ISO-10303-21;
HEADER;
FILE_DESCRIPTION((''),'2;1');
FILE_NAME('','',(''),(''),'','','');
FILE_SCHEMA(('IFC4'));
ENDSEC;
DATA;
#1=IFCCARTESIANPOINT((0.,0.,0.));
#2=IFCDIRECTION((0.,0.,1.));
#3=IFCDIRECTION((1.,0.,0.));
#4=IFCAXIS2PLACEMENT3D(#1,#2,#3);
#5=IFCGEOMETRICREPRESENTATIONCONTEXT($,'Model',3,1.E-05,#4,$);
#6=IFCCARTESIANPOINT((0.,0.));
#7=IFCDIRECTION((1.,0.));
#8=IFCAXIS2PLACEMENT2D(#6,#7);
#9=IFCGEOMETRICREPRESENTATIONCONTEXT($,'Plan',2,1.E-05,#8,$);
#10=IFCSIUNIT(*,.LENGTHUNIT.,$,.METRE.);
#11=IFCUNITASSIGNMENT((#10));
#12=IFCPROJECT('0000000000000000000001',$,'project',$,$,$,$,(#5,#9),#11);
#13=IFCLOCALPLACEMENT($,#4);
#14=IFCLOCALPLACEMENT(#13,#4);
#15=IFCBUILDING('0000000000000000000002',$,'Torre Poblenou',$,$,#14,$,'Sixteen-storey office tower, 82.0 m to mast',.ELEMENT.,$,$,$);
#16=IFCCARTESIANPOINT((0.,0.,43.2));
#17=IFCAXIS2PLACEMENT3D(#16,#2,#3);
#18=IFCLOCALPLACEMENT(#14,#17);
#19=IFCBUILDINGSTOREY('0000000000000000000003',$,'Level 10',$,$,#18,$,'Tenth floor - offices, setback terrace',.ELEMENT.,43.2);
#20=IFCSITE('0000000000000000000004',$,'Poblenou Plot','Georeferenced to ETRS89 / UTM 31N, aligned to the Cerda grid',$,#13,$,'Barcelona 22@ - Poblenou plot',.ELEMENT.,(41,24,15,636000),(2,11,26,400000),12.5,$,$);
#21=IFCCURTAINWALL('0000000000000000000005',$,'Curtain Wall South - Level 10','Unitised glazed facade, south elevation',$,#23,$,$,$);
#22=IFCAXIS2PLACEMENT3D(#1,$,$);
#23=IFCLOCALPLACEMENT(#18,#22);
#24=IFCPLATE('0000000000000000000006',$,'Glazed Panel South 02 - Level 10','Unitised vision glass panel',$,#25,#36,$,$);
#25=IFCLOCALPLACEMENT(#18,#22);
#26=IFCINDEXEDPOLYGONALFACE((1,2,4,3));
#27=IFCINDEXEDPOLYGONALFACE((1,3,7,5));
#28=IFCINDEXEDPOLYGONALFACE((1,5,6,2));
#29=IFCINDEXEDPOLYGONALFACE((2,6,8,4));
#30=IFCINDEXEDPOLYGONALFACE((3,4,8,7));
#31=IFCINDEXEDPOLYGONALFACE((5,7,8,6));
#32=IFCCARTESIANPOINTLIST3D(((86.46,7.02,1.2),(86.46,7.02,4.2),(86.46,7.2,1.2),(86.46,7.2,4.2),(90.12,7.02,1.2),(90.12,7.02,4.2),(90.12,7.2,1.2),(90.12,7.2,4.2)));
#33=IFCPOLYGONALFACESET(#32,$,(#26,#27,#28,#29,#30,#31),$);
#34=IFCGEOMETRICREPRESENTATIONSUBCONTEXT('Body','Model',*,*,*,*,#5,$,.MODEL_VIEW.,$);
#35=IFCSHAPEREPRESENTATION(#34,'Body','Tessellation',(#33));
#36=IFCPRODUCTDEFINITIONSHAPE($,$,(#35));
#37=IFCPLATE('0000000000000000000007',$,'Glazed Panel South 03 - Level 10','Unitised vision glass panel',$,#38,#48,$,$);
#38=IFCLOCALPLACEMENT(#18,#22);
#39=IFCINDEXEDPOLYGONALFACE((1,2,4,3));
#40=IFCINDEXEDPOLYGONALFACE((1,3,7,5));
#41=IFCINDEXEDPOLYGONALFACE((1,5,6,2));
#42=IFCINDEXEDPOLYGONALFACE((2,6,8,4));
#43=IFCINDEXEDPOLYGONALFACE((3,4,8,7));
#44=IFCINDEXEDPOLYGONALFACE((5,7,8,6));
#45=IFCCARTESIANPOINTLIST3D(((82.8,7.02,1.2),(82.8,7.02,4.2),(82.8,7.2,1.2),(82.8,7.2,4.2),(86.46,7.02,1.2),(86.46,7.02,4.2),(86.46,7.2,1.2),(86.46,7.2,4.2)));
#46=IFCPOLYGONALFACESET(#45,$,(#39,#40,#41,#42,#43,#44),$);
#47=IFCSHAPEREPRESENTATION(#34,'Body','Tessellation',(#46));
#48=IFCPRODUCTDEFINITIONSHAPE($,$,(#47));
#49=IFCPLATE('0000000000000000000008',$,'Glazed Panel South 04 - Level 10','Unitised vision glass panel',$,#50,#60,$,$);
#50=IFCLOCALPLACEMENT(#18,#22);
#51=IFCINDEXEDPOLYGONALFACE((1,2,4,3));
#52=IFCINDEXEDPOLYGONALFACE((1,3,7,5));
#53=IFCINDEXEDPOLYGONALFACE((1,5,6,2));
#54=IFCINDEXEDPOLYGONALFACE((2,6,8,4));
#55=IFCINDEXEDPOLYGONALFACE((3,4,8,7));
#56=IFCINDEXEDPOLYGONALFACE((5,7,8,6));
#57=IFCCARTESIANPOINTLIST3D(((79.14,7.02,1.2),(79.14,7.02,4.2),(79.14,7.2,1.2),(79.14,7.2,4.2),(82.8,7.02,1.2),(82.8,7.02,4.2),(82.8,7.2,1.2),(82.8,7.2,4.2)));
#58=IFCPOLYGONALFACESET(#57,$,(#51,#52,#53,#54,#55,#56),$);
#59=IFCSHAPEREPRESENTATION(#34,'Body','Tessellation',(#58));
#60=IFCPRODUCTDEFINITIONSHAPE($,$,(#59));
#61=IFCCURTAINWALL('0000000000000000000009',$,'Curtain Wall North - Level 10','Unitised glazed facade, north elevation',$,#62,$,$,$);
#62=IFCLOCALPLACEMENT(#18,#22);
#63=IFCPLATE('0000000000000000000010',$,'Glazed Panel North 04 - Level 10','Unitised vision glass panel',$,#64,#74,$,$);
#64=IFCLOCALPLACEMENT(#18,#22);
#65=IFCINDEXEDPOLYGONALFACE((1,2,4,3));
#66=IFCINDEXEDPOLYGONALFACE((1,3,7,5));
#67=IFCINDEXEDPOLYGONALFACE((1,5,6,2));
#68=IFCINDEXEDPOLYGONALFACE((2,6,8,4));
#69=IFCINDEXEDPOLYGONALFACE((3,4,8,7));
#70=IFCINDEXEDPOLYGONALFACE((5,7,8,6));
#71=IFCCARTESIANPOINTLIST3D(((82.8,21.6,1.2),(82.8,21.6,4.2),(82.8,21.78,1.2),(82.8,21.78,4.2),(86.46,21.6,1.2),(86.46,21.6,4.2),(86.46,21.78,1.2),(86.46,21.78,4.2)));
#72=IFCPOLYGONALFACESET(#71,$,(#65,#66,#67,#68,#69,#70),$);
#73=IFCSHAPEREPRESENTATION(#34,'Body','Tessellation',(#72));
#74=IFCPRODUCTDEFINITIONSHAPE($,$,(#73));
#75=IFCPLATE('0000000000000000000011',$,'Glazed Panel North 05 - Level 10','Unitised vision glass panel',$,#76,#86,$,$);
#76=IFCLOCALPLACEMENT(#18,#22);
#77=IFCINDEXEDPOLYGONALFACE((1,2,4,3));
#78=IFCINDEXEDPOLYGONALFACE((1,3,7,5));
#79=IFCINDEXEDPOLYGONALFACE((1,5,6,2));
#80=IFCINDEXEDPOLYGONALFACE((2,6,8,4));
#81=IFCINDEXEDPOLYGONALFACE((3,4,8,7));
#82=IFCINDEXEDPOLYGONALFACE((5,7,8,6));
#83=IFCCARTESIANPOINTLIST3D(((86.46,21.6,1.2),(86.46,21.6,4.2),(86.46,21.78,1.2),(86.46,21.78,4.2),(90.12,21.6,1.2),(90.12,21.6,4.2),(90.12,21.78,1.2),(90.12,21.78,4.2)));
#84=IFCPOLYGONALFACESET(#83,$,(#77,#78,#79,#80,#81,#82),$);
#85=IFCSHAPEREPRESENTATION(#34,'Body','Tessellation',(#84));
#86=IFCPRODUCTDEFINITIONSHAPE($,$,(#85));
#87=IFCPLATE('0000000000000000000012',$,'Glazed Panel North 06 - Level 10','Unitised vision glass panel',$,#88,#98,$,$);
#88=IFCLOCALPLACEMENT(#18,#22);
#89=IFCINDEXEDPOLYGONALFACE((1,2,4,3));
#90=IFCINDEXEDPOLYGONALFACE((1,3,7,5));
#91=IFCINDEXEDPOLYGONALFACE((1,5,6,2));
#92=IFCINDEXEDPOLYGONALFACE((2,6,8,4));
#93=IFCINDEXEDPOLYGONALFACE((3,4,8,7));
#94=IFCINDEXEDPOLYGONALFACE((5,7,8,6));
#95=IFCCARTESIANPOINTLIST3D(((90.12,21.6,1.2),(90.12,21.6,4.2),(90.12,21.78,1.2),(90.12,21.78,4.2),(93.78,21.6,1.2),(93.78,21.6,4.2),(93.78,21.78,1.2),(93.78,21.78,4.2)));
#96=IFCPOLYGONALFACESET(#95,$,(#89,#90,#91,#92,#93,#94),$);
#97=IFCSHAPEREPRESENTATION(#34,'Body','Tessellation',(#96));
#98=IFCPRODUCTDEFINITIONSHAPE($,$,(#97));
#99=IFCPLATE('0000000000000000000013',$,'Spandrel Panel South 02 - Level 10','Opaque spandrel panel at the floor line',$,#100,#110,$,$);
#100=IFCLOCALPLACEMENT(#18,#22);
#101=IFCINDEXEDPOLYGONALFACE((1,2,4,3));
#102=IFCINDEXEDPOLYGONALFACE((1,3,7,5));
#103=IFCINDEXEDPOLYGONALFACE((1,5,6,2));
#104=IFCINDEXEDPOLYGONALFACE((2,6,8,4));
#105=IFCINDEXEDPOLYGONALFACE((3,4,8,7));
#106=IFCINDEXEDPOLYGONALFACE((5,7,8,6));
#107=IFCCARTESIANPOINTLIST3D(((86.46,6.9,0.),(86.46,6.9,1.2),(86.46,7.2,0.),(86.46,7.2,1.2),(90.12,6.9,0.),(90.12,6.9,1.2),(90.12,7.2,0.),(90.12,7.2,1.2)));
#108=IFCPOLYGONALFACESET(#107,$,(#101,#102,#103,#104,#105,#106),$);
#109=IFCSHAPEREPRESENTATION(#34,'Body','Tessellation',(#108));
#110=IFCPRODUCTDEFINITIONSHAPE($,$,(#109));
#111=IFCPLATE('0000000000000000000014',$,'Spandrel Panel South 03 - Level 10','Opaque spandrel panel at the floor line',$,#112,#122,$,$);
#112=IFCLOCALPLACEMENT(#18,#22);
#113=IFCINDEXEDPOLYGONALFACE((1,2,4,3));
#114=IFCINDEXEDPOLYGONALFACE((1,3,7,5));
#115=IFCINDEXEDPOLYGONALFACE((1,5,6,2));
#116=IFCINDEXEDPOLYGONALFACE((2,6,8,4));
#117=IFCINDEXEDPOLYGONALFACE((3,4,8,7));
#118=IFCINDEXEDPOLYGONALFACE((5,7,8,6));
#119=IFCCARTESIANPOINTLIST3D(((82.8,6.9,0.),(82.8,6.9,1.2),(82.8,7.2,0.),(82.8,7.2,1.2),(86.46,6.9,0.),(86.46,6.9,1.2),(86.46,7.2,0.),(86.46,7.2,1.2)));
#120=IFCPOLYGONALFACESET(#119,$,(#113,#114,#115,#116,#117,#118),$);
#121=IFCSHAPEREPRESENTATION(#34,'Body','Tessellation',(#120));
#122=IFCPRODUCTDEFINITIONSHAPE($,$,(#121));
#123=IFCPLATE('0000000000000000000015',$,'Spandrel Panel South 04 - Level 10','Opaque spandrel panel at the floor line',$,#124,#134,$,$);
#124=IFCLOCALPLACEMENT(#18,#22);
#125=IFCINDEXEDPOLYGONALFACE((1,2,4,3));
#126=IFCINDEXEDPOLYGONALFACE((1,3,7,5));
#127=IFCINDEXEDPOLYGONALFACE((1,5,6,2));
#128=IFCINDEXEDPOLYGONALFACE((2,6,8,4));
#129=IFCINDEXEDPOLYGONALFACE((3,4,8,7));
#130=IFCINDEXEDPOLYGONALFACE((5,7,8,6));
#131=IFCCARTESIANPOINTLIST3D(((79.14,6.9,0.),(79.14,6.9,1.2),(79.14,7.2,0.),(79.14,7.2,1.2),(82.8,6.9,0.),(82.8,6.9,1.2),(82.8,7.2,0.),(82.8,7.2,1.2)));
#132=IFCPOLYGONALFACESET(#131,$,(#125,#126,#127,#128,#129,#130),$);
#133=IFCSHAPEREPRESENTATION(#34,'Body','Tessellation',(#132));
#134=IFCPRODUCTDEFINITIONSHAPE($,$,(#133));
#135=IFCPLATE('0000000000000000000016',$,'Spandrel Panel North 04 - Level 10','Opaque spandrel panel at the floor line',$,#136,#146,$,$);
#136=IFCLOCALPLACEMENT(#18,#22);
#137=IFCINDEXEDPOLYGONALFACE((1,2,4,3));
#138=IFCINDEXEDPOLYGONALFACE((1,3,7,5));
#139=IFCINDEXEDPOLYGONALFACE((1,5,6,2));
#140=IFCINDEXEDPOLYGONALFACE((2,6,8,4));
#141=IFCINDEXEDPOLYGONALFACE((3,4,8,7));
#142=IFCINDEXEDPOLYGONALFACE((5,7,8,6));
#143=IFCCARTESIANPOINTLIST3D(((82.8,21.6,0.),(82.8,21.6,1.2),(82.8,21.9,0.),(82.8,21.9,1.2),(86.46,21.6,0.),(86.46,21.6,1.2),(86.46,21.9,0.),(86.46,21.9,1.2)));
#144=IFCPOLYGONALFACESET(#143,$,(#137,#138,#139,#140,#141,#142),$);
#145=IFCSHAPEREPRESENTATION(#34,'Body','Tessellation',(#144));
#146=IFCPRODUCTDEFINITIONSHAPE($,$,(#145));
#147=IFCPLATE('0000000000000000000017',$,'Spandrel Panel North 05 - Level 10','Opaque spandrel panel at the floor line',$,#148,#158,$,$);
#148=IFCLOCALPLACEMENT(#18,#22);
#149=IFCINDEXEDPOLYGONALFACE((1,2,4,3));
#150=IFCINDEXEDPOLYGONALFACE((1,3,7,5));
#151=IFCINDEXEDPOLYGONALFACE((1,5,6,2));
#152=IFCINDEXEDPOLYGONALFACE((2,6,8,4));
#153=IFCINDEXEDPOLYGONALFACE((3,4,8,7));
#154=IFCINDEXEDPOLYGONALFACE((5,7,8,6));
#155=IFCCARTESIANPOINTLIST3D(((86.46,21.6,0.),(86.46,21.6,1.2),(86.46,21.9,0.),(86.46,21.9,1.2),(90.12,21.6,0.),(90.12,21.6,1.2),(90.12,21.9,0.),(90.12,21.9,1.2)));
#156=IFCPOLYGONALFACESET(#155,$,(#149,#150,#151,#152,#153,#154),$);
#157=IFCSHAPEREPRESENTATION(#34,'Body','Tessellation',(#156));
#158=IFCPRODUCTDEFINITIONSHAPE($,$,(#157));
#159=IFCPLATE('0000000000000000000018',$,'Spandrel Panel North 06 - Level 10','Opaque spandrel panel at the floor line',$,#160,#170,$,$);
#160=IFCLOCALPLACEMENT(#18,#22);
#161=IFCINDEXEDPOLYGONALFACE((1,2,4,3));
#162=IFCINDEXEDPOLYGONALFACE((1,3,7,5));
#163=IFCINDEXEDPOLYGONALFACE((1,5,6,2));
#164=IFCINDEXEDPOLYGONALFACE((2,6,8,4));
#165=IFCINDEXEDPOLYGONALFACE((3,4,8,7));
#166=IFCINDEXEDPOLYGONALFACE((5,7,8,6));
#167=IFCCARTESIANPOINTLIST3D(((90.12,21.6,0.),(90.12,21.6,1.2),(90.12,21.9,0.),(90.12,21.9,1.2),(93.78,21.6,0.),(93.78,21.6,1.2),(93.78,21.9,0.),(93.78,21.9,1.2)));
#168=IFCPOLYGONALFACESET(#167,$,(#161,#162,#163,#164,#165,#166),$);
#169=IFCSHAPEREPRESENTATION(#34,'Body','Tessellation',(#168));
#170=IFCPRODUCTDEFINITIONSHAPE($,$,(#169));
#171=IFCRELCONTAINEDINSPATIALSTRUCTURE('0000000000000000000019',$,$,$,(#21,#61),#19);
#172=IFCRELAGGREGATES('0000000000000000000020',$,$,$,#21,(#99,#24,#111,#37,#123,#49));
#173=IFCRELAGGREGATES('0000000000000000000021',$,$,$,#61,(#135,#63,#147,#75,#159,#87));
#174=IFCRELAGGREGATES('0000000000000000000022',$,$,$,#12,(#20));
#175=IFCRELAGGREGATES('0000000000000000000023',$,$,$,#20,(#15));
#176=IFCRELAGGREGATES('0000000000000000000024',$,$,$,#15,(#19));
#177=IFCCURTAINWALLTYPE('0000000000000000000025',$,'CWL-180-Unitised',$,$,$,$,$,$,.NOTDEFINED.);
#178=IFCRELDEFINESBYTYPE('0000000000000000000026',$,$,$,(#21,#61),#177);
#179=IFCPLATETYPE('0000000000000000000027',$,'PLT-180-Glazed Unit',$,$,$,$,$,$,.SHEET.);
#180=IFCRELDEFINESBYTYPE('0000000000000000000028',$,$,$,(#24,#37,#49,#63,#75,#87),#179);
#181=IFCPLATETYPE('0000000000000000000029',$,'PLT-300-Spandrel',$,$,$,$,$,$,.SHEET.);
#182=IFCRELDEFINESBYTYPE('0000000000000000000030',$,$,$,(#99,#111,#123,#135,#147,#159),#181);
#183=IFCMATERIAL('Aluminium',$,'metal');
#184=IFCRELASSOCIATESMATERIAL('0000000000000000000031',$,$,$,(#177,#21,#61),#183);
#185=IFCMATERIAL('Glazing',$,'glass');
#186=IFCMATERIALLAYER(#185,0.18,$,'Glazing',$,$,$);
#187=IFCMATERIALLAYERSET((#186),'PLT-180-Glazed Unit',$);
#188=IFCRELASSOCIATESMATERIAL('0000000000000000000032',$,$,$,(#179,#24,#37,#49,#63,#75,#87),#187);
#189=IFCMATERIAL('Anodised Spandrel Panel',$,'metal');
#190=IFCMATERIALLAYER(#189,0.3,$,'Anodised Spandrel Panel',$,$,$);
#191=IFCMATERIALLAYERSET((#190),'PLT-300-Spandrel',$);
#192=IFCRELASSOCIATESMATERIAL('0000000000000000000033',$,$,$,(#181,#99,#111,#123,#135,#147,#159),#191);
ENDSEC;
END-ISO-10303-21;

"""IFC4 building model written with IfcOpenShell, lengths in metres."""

from ifc_helpers import new_model, si_unit, frame, origin_with_axes, origin_2d_with_axis, place, context, subcontext, project, spatial, line, indexed_curve, outline, extrude, material, layer, layer_set, layer_usage, type_object, element, aggregate, save


model = new_model("IFC4")

# Units and contexts
model_context = context("Model", 3, precision=1e-05, world=origin_with_axes())
plan_context = context("Plan", 2, precision=1e-05, world=origin_2d_with_axis())
body_context = subcontext(model_context, "Body", "Model", "MODEL_VIEW")
ifc_project = project(units=[si_unit("LENGTHUNIT", "METRE")], contexts=[model_context, plan_context])

# Site, building, storey
site_placement = place(None, origin_with_axes())
site = spatial("IfcSite", under=ifc_project, at=site_placement, Name="Poblenou Plot", Description="Georeferenced to ETRS89 / UTM 31N, aligned to the Cerda grid", LongName="Barcelona 22@ - Poblenou plot", CompositionType="ELEMENT", RefLatitude=(41, 24, 15, 636000), RefLongitude=(2, 11, 26, 400000), RefElevation=12.5)
building_placement = place(site_placement, origin_with_axes())
building = spatial("IfcBuilding", under=site, at=building_placement, Name="Torre Poblenou", LongName="Sixteen-storey office tower, 82.0 m to mast", CompositionType="ELEMENT")
storey_placement = place(building_placement, frame((0.0, 0.0, 43.2), z_axis=(0.0, 0.0, 1.0), x_axis=(1.0, 0.0, 0.0)))
storey = spatial("IfcBuildingStorey", under=building, at=storey_placement, Name="Level 10", LongName="Tenth floor - offices, setback terrace", CompositionType="ELEMENT", Elevation=43.2)

# Shared definitions
ifc_material_1 = material(Name="Aluminium", Category="metal")

# Curtain walls, plates
curtain_wall_type = type_object("IfcCurtainWallType", Name="CWL-180-Unitised", PredefinedType="NOTDEFINED", material=ifc_material_1)
curtain_wall_1_placement = place(storey_placement, frame((93.78, 7.2, 0.0), z_axis=(0.0, 0.0, 1.0), x_axis=(-1.0, 0.0, 0.0)))
curtain_wall_1 = element("IfcCurtainWall", 1, at=curtain_wall_1_placement, inside=storey, type_object=curtain_wall_type, material=ifc_material_1, Name="Curtain Wall South - Level 10", Description="Unitised glazed facade, south elevation")
ifc_material_2 = material(Name="Glazing", Category="glass")
ifc_layer_1 = layer(ifc_material_2, 0.18, Name="Glazing")
ifc_layer_set_1 = layer_set([ifc_layer_1], Name="PLT-180-Glazed Unit")
ifc_layer_usage_1 = layer_usage(ifc_layer_set_1, "AXIS2", "POSITIVE", 0.0)
plate_type_1 = type_object("IfcPlateType", Name="PLT-180-Glazed Unit", PredefinedType="SHEET", material=ifc_layer_set_1)
plate_1_placement = place(curtain_wall_1_placement, frame((3.66, 0.0, 1.2), z_axis=(0.0, 0.0, 1.0), x_axis=(1.0, 0.0, 0.0)))
plate_1 = element("IfcPlate", 2, at=plate_1_placement, type_object=plate_type_1, material=ifc_layer_usage_1, Name="Glazed Panel South 02 - Level 10", Description="Unitised vision glass panel", context=body_context, shape_type="SweptSolid", body=[
    extrude(outline(indexed_curve([(0.0, 0.0), (3.66, 0.0), (3.66, 0.18), (0.0, 0.18)], segments=[line(1, 2, 3, 4, 1)])), origin_with_axes(), (0.0, 0.0, 1.0), 3.0),
])
ifc_layer_usage_2 = layer_usage(ifc_layer_set_1, "AXIS2", "POSITIVE", 0.0)
plate_2_placement = place(curtain_wall_1_placement, frame((7.32, 0.0, 1.2), z_axis=(0.0, 0.0, 1.0), x_axis=(1.0, 0.0, 0.0)))
plate_2 = element("IfcPlate", 3, at=plate_2_placement, type_object=plate_type_1, material=ifc_layer_usage_2, Name="Glazed Panel South 03 - Level 10", Description="Unitised vision glass panel", context=body_context, shape_type="SweptSolid", body=[
    extrude(outline(indexed_curve([(0.0, 0.0), (3.66, 0.0), (3.66, 0.18), (0.0, 0.18)], segments=[line(1, 2, 3, 4, 1)])), origin_with_axes(), (0.0, 0.0, 1.0), 3.0),
])
ifc_layer_usage_3 = layer_usage(ifc_layer_set_1, "AXIS2", "POSITIVE", 0.0)
plate_3_placement = place(curtain_wall_1_placement, frame((10.98, 0.0, 1.2), z_axis=(0.0, 0.0, 1.0), x_axis=(1.0, 0.0, 0.0)))
plate_3 = element("IfcPlate", 4, at=plate_3_placement, type_object=plate_type_1, material=ifc_layer_usage_3, Name="Glazed Panel South 04 - Level 10", Description="Unitised vision glass panel", context=body_context, shape_type="SweptSolid", body=[
    extrude(outline(indexed_curve([(0.0, 0.0), (3.66, 0.0), (3.66, 0.18), (0.0, 0.18)], segments=[line(1, 2, 3, 4, 1)])), origin_with_axes(), (0.0, 0.0, 1.0), 3.0),
])
curtain_wall_2_placement = place(storey_placement, frame((71.82, 21.6, 0.0), z_axis=(0.0, 0.0, 1.0), x_axis=(1.0, 0.0, 0.0)))
curtain_wall_2 = element("IfcCurtainWall", 5, at=curtain_wall_2_placement, inside=storey, type_object=curtain_wall_type, material=ifc_material_1, Name="Curtain Wall North - Level 10", Description="Unitised glazed facade, north elevation")
ifc_layer_usage_4 = layer_usage(ifc_layer_set_1, "AXIS2", "POSITIVE", 0.0)
plate_4_placement = place(curtain_wall_2_placement, frame((10.98, 0.0, 1.2), z_axis=(0.0, 0.0, 1.0), x_axis=(1.0, 0.0, 0.0)))
plate_4 = element("IfcPlate", 6, at=plate_4_placement, type_object=plate_type_1, material=ifc_layer_usage_4, Name="Glazed Panel North 04 - Level 10", Description="Unitised vision glass panel", context=body_context, shape_type="SweptSolid", body=[
    extrude(outline(indexed_curve([(0.0, 0.0), (3.66, 0.0), (3.66, 0.18), (0.0, 0.18)], segments=[line(1, 2, 3, 4, 1)])), origin_with_axes(), (0.0, 0.0, 1.0), 3.0),
])
ifc_layer_usage_5 = layer_usage(ifc_layer_set_1, "AXIS2", "POSITIVE", 0.0)
plate_5_placement = place(curtain_wall_2_placement, frame((14.64, 0.0, 1.2), z_axis=(0.0, 0.0, 1.0), x_axis=(1.0, 0.0, 0.0)))
plate_5 = element("IfcPlate", 7, at=plate_5_placement, type_object=plate_type_1, material=ifc_layer_usage_5, Name="Glazed Panel North 05 - Level 10", Description="Unitised vision glass panel", context=body_context, shape_type="SweptSolid", body=[
    extrude(outline(indexed_curve([(0.0, 0.0), (3.66, 0.0), (3.66, 0.18), (0.0, 0.18)], segments=[line(1, 2, 3, 4, 1)])), origin_with_axes(), (0.0, 0.0, 1.0), 3.0),
])
ifc_layer_usage_6 = layer_usage(ifc_layer_set_1, "AXIS2", "POSITIVE", 0.0)
plate_6_placement = place(curtain_wall_2_placement, frame((18.3, 0.0, 1.2), z_axis=(0.0, 0.0, 1.0), x_axis=(1.0, 0.0, 0.0)))
plate_6 = element("IfcPlate", 8, at=plate_6_placement, type_object=plate_type_1, material=ifc_layer_usage_6, Name="Glazed Panel North 06 - Level 10", Description="Unitised vision glass panel", context=body_context, shape_type="SweptSolid", body=[
    extrude(outline(indexed_curve([(0.0, 0.0), (3.66, 0.0), (3.66, 0.18), (0.0, 0.18)], segments=[line(1, 2, 3, 4, 1)])), origin_with_axes(), (0.0, 0.0, 1.0), 3.0),
])

# Plates
ifc_material_3 = material(Name="Anodised Spandrel Panel", Category="metal")
ifc_layer_2 = layer(ifc_material_3, 0.3, Name="Anodised Spandrel Panel")
ifc_layer_set_2 = layer_set([ifc_layer_2], Name="PLT-300-Spandrel")
ifc_layer_usage_7 = layer_usage(ifc_layer_set_2, "AXIS2", "POSITIVE", 0.0)
plate_type_2 = type_object("IfcPlateType", Name="PLT-300-Spandrel", PredefinedType="SHEET", material=ifc_layer_set_2)
plate_7_placement = place(curtain_wall_1_placement, frame((3.66, 0.0, 0.0), z_axis=(0.0, 0.0, 1.0), x_axis=(1.0, 0.0, 0.0)))
plate_7 = element("IfcPlate", 9, at=plate_7_placement, type_object=plate_type_2, material=ifc_layer_usage_7, Name="Spandrel Panel South 02 - Level 10", Description="Opaque spandrel panel at the floor line", context=body_context, shape_type="SweptSolid", body=[
    extrude(outline(indexed_curve([(0.0, 0.0), (3.66, 0.0), (3.66, 0.3), (0.0, 0.3)], segments=[line(1, 2, 3, 4, 1)])), origin_with_axes(), (0.0, 0.0, 1.0), 1.2),
])
ifc_layer_usage_8 = layer_usage(ifc_layer_set_2, "AXIS2", "POSITIVE", 0.0)
plate_8_placement = place(curtain_wall_1_placement, frame((7.32, 0.0, 0.0), z_axis=(0.0, 0.0, 1.0), x_axis=(1.0, 0.0, 0.0)))
plate_8 = element("IfcPlate", 10, at=plate_8_placement, type_object=plate_type_2, material=ifc_layer_usage_8, Name="Spandrel Panel South 03 - Level 10", Description="Opaque spandrel panel at the floor line", context=body_context, shape_type="SweptSolid", body=[
    extrude(outline(indexed_curve([(0.0, 0.0), (3.66, 0.0), (3.66, 0.3), (0.0, 0.3)], segments=[line(1, 2, 3, 4, 1)])), origin_with_axes(), (0.0, 0.0, 1.0), 1.2),
])
ifc_layer_usage_9 = layer_usage(ifc_layer_set_2, "AXIS2", "POSITIVE", 0.0)
plate_9_placement = place(curtain_wall_1_placement, frame((10.98, 0.0, 0.0), z_axis=(0.0, 0.0, 1.0), x_axis=(1.0, 0.0, 0.0)))
plate_9 = element("IfcPlate", 11, at=plate_9_placement, type_object=plate_type_2, material=ifc_layer_usage_9, Name="Spandrel Panel South 04 - Level 10", Description="Opaque spandrel panel at the floor line", context=body_context, shape_type="SweptSolid", body=[
    extrude(outline(indexed_curve([(0.0, 0.0), (3.66, 0.0), (3.66, 0.3), (0.0, 0.3)], segments=[line(1, 2, 3, 4, 1)])), origin_with_axes(), (0.0, 0.0, 1.0), 1.2),
])
aggregate(curtain_wall_1, [plate_7, plate_1, plate_8, plate_2, plate_9, plate_3])
ifc_layer_usage_10 = layer_usage(ifc_layer_set_2, "AXIS2", "POSITIVE", 0.0)
plate_10_placement = place(curtain_wall_2_placement, frame((10.98, 0.0, 0.0), z_axis=(0.0, 0.0, 1.0), x_axis=(1.0, 0.0, 0.0)))
plate_10 = element("IfcPlate", 12, at=plate_10_placement, type_object=plate_type_2, material=ifc_layer_usage_10, Name="Spandrel Panel North 04 - Level 10", Description="Opaque spandrel panel at the floor line", context=body_context, shape_type="SweptSolid", body=[
    extrude(outline(indexed_curve([(0.0, 0.0), (3.66, 0.0), (3.66, 0.3), (0.0, 0.3)], segments=[line(1, 2, 3, 4, 1)])), origin_with_axes(), (0.0, 0.0, 1.0), 1.2),
])
ifc_layer_usage_11 = layer_usage(ifc_layer_set_2, "AXIS2", "POSITIVE", 0.0)
plate_11_placement = place(curtain_wall_2_placement, frame((14.64, 0.0, 0.0), z_axis=(0.0, 0.0, 1.0), x_axis=(1.0, 0.0, 0.0)))
plate_11 = element("IfcPlate", 13, at=plate_11_placement, type_object=plate_type_2, material=ifc_layer_usage_11, Name="Spandrel Panel North 05 - Level 10", Description="Opaque spandrel panel at the floor line", context=body_context, shape_type="SweptSolid", body=[
    extrude(outline(indexed_curve([(0.0, 0.0), (3.66, 0.0), (3.66, 0.3), (0.0, 0.3)], segments=[line(1, 2, 3, 4, 1)])), origin_with_axes(), (0.0, 0.0, 1.0), 1.2),
])
ifc_layer_usage_12 = layer_usage(ifc_layer_set_2, "AXIS2", "POSITIVE", 0.0)
plate_12_placement = place(curtain_wall_2_placement, frame((18.3, 0.0, 0.0), z_axis=(0.0, 0.0, 1.0), x_axis=(1.0, 0.0, 0.0)))
plate_12 = element("IfcPlate", 14, at=plate_12_placement, type_object=plate_type_2, material=ifc_layer_usage_12, Name="Spandrel Panel North 06 - Level 10", Description="Opaque spandrel panel at the floor line", context=body_context, shape_type="SweptSolid", body=[
    extrude(outline(indexed_curve([(0.0, 0.0), (3.66, 0.0), (3.66, 0.3), (0.0, 0.3)], segments=[line(1, 2, 3, 4, 1)])), origin_with_axes(), (0.0, 0.0, 1.0), 1.2),
])
aggregate(curtain_wall_2, [plate_10, plate_4, plate_11, plate_5, plate_12, plate_6])

save(model, "model.ifc")
